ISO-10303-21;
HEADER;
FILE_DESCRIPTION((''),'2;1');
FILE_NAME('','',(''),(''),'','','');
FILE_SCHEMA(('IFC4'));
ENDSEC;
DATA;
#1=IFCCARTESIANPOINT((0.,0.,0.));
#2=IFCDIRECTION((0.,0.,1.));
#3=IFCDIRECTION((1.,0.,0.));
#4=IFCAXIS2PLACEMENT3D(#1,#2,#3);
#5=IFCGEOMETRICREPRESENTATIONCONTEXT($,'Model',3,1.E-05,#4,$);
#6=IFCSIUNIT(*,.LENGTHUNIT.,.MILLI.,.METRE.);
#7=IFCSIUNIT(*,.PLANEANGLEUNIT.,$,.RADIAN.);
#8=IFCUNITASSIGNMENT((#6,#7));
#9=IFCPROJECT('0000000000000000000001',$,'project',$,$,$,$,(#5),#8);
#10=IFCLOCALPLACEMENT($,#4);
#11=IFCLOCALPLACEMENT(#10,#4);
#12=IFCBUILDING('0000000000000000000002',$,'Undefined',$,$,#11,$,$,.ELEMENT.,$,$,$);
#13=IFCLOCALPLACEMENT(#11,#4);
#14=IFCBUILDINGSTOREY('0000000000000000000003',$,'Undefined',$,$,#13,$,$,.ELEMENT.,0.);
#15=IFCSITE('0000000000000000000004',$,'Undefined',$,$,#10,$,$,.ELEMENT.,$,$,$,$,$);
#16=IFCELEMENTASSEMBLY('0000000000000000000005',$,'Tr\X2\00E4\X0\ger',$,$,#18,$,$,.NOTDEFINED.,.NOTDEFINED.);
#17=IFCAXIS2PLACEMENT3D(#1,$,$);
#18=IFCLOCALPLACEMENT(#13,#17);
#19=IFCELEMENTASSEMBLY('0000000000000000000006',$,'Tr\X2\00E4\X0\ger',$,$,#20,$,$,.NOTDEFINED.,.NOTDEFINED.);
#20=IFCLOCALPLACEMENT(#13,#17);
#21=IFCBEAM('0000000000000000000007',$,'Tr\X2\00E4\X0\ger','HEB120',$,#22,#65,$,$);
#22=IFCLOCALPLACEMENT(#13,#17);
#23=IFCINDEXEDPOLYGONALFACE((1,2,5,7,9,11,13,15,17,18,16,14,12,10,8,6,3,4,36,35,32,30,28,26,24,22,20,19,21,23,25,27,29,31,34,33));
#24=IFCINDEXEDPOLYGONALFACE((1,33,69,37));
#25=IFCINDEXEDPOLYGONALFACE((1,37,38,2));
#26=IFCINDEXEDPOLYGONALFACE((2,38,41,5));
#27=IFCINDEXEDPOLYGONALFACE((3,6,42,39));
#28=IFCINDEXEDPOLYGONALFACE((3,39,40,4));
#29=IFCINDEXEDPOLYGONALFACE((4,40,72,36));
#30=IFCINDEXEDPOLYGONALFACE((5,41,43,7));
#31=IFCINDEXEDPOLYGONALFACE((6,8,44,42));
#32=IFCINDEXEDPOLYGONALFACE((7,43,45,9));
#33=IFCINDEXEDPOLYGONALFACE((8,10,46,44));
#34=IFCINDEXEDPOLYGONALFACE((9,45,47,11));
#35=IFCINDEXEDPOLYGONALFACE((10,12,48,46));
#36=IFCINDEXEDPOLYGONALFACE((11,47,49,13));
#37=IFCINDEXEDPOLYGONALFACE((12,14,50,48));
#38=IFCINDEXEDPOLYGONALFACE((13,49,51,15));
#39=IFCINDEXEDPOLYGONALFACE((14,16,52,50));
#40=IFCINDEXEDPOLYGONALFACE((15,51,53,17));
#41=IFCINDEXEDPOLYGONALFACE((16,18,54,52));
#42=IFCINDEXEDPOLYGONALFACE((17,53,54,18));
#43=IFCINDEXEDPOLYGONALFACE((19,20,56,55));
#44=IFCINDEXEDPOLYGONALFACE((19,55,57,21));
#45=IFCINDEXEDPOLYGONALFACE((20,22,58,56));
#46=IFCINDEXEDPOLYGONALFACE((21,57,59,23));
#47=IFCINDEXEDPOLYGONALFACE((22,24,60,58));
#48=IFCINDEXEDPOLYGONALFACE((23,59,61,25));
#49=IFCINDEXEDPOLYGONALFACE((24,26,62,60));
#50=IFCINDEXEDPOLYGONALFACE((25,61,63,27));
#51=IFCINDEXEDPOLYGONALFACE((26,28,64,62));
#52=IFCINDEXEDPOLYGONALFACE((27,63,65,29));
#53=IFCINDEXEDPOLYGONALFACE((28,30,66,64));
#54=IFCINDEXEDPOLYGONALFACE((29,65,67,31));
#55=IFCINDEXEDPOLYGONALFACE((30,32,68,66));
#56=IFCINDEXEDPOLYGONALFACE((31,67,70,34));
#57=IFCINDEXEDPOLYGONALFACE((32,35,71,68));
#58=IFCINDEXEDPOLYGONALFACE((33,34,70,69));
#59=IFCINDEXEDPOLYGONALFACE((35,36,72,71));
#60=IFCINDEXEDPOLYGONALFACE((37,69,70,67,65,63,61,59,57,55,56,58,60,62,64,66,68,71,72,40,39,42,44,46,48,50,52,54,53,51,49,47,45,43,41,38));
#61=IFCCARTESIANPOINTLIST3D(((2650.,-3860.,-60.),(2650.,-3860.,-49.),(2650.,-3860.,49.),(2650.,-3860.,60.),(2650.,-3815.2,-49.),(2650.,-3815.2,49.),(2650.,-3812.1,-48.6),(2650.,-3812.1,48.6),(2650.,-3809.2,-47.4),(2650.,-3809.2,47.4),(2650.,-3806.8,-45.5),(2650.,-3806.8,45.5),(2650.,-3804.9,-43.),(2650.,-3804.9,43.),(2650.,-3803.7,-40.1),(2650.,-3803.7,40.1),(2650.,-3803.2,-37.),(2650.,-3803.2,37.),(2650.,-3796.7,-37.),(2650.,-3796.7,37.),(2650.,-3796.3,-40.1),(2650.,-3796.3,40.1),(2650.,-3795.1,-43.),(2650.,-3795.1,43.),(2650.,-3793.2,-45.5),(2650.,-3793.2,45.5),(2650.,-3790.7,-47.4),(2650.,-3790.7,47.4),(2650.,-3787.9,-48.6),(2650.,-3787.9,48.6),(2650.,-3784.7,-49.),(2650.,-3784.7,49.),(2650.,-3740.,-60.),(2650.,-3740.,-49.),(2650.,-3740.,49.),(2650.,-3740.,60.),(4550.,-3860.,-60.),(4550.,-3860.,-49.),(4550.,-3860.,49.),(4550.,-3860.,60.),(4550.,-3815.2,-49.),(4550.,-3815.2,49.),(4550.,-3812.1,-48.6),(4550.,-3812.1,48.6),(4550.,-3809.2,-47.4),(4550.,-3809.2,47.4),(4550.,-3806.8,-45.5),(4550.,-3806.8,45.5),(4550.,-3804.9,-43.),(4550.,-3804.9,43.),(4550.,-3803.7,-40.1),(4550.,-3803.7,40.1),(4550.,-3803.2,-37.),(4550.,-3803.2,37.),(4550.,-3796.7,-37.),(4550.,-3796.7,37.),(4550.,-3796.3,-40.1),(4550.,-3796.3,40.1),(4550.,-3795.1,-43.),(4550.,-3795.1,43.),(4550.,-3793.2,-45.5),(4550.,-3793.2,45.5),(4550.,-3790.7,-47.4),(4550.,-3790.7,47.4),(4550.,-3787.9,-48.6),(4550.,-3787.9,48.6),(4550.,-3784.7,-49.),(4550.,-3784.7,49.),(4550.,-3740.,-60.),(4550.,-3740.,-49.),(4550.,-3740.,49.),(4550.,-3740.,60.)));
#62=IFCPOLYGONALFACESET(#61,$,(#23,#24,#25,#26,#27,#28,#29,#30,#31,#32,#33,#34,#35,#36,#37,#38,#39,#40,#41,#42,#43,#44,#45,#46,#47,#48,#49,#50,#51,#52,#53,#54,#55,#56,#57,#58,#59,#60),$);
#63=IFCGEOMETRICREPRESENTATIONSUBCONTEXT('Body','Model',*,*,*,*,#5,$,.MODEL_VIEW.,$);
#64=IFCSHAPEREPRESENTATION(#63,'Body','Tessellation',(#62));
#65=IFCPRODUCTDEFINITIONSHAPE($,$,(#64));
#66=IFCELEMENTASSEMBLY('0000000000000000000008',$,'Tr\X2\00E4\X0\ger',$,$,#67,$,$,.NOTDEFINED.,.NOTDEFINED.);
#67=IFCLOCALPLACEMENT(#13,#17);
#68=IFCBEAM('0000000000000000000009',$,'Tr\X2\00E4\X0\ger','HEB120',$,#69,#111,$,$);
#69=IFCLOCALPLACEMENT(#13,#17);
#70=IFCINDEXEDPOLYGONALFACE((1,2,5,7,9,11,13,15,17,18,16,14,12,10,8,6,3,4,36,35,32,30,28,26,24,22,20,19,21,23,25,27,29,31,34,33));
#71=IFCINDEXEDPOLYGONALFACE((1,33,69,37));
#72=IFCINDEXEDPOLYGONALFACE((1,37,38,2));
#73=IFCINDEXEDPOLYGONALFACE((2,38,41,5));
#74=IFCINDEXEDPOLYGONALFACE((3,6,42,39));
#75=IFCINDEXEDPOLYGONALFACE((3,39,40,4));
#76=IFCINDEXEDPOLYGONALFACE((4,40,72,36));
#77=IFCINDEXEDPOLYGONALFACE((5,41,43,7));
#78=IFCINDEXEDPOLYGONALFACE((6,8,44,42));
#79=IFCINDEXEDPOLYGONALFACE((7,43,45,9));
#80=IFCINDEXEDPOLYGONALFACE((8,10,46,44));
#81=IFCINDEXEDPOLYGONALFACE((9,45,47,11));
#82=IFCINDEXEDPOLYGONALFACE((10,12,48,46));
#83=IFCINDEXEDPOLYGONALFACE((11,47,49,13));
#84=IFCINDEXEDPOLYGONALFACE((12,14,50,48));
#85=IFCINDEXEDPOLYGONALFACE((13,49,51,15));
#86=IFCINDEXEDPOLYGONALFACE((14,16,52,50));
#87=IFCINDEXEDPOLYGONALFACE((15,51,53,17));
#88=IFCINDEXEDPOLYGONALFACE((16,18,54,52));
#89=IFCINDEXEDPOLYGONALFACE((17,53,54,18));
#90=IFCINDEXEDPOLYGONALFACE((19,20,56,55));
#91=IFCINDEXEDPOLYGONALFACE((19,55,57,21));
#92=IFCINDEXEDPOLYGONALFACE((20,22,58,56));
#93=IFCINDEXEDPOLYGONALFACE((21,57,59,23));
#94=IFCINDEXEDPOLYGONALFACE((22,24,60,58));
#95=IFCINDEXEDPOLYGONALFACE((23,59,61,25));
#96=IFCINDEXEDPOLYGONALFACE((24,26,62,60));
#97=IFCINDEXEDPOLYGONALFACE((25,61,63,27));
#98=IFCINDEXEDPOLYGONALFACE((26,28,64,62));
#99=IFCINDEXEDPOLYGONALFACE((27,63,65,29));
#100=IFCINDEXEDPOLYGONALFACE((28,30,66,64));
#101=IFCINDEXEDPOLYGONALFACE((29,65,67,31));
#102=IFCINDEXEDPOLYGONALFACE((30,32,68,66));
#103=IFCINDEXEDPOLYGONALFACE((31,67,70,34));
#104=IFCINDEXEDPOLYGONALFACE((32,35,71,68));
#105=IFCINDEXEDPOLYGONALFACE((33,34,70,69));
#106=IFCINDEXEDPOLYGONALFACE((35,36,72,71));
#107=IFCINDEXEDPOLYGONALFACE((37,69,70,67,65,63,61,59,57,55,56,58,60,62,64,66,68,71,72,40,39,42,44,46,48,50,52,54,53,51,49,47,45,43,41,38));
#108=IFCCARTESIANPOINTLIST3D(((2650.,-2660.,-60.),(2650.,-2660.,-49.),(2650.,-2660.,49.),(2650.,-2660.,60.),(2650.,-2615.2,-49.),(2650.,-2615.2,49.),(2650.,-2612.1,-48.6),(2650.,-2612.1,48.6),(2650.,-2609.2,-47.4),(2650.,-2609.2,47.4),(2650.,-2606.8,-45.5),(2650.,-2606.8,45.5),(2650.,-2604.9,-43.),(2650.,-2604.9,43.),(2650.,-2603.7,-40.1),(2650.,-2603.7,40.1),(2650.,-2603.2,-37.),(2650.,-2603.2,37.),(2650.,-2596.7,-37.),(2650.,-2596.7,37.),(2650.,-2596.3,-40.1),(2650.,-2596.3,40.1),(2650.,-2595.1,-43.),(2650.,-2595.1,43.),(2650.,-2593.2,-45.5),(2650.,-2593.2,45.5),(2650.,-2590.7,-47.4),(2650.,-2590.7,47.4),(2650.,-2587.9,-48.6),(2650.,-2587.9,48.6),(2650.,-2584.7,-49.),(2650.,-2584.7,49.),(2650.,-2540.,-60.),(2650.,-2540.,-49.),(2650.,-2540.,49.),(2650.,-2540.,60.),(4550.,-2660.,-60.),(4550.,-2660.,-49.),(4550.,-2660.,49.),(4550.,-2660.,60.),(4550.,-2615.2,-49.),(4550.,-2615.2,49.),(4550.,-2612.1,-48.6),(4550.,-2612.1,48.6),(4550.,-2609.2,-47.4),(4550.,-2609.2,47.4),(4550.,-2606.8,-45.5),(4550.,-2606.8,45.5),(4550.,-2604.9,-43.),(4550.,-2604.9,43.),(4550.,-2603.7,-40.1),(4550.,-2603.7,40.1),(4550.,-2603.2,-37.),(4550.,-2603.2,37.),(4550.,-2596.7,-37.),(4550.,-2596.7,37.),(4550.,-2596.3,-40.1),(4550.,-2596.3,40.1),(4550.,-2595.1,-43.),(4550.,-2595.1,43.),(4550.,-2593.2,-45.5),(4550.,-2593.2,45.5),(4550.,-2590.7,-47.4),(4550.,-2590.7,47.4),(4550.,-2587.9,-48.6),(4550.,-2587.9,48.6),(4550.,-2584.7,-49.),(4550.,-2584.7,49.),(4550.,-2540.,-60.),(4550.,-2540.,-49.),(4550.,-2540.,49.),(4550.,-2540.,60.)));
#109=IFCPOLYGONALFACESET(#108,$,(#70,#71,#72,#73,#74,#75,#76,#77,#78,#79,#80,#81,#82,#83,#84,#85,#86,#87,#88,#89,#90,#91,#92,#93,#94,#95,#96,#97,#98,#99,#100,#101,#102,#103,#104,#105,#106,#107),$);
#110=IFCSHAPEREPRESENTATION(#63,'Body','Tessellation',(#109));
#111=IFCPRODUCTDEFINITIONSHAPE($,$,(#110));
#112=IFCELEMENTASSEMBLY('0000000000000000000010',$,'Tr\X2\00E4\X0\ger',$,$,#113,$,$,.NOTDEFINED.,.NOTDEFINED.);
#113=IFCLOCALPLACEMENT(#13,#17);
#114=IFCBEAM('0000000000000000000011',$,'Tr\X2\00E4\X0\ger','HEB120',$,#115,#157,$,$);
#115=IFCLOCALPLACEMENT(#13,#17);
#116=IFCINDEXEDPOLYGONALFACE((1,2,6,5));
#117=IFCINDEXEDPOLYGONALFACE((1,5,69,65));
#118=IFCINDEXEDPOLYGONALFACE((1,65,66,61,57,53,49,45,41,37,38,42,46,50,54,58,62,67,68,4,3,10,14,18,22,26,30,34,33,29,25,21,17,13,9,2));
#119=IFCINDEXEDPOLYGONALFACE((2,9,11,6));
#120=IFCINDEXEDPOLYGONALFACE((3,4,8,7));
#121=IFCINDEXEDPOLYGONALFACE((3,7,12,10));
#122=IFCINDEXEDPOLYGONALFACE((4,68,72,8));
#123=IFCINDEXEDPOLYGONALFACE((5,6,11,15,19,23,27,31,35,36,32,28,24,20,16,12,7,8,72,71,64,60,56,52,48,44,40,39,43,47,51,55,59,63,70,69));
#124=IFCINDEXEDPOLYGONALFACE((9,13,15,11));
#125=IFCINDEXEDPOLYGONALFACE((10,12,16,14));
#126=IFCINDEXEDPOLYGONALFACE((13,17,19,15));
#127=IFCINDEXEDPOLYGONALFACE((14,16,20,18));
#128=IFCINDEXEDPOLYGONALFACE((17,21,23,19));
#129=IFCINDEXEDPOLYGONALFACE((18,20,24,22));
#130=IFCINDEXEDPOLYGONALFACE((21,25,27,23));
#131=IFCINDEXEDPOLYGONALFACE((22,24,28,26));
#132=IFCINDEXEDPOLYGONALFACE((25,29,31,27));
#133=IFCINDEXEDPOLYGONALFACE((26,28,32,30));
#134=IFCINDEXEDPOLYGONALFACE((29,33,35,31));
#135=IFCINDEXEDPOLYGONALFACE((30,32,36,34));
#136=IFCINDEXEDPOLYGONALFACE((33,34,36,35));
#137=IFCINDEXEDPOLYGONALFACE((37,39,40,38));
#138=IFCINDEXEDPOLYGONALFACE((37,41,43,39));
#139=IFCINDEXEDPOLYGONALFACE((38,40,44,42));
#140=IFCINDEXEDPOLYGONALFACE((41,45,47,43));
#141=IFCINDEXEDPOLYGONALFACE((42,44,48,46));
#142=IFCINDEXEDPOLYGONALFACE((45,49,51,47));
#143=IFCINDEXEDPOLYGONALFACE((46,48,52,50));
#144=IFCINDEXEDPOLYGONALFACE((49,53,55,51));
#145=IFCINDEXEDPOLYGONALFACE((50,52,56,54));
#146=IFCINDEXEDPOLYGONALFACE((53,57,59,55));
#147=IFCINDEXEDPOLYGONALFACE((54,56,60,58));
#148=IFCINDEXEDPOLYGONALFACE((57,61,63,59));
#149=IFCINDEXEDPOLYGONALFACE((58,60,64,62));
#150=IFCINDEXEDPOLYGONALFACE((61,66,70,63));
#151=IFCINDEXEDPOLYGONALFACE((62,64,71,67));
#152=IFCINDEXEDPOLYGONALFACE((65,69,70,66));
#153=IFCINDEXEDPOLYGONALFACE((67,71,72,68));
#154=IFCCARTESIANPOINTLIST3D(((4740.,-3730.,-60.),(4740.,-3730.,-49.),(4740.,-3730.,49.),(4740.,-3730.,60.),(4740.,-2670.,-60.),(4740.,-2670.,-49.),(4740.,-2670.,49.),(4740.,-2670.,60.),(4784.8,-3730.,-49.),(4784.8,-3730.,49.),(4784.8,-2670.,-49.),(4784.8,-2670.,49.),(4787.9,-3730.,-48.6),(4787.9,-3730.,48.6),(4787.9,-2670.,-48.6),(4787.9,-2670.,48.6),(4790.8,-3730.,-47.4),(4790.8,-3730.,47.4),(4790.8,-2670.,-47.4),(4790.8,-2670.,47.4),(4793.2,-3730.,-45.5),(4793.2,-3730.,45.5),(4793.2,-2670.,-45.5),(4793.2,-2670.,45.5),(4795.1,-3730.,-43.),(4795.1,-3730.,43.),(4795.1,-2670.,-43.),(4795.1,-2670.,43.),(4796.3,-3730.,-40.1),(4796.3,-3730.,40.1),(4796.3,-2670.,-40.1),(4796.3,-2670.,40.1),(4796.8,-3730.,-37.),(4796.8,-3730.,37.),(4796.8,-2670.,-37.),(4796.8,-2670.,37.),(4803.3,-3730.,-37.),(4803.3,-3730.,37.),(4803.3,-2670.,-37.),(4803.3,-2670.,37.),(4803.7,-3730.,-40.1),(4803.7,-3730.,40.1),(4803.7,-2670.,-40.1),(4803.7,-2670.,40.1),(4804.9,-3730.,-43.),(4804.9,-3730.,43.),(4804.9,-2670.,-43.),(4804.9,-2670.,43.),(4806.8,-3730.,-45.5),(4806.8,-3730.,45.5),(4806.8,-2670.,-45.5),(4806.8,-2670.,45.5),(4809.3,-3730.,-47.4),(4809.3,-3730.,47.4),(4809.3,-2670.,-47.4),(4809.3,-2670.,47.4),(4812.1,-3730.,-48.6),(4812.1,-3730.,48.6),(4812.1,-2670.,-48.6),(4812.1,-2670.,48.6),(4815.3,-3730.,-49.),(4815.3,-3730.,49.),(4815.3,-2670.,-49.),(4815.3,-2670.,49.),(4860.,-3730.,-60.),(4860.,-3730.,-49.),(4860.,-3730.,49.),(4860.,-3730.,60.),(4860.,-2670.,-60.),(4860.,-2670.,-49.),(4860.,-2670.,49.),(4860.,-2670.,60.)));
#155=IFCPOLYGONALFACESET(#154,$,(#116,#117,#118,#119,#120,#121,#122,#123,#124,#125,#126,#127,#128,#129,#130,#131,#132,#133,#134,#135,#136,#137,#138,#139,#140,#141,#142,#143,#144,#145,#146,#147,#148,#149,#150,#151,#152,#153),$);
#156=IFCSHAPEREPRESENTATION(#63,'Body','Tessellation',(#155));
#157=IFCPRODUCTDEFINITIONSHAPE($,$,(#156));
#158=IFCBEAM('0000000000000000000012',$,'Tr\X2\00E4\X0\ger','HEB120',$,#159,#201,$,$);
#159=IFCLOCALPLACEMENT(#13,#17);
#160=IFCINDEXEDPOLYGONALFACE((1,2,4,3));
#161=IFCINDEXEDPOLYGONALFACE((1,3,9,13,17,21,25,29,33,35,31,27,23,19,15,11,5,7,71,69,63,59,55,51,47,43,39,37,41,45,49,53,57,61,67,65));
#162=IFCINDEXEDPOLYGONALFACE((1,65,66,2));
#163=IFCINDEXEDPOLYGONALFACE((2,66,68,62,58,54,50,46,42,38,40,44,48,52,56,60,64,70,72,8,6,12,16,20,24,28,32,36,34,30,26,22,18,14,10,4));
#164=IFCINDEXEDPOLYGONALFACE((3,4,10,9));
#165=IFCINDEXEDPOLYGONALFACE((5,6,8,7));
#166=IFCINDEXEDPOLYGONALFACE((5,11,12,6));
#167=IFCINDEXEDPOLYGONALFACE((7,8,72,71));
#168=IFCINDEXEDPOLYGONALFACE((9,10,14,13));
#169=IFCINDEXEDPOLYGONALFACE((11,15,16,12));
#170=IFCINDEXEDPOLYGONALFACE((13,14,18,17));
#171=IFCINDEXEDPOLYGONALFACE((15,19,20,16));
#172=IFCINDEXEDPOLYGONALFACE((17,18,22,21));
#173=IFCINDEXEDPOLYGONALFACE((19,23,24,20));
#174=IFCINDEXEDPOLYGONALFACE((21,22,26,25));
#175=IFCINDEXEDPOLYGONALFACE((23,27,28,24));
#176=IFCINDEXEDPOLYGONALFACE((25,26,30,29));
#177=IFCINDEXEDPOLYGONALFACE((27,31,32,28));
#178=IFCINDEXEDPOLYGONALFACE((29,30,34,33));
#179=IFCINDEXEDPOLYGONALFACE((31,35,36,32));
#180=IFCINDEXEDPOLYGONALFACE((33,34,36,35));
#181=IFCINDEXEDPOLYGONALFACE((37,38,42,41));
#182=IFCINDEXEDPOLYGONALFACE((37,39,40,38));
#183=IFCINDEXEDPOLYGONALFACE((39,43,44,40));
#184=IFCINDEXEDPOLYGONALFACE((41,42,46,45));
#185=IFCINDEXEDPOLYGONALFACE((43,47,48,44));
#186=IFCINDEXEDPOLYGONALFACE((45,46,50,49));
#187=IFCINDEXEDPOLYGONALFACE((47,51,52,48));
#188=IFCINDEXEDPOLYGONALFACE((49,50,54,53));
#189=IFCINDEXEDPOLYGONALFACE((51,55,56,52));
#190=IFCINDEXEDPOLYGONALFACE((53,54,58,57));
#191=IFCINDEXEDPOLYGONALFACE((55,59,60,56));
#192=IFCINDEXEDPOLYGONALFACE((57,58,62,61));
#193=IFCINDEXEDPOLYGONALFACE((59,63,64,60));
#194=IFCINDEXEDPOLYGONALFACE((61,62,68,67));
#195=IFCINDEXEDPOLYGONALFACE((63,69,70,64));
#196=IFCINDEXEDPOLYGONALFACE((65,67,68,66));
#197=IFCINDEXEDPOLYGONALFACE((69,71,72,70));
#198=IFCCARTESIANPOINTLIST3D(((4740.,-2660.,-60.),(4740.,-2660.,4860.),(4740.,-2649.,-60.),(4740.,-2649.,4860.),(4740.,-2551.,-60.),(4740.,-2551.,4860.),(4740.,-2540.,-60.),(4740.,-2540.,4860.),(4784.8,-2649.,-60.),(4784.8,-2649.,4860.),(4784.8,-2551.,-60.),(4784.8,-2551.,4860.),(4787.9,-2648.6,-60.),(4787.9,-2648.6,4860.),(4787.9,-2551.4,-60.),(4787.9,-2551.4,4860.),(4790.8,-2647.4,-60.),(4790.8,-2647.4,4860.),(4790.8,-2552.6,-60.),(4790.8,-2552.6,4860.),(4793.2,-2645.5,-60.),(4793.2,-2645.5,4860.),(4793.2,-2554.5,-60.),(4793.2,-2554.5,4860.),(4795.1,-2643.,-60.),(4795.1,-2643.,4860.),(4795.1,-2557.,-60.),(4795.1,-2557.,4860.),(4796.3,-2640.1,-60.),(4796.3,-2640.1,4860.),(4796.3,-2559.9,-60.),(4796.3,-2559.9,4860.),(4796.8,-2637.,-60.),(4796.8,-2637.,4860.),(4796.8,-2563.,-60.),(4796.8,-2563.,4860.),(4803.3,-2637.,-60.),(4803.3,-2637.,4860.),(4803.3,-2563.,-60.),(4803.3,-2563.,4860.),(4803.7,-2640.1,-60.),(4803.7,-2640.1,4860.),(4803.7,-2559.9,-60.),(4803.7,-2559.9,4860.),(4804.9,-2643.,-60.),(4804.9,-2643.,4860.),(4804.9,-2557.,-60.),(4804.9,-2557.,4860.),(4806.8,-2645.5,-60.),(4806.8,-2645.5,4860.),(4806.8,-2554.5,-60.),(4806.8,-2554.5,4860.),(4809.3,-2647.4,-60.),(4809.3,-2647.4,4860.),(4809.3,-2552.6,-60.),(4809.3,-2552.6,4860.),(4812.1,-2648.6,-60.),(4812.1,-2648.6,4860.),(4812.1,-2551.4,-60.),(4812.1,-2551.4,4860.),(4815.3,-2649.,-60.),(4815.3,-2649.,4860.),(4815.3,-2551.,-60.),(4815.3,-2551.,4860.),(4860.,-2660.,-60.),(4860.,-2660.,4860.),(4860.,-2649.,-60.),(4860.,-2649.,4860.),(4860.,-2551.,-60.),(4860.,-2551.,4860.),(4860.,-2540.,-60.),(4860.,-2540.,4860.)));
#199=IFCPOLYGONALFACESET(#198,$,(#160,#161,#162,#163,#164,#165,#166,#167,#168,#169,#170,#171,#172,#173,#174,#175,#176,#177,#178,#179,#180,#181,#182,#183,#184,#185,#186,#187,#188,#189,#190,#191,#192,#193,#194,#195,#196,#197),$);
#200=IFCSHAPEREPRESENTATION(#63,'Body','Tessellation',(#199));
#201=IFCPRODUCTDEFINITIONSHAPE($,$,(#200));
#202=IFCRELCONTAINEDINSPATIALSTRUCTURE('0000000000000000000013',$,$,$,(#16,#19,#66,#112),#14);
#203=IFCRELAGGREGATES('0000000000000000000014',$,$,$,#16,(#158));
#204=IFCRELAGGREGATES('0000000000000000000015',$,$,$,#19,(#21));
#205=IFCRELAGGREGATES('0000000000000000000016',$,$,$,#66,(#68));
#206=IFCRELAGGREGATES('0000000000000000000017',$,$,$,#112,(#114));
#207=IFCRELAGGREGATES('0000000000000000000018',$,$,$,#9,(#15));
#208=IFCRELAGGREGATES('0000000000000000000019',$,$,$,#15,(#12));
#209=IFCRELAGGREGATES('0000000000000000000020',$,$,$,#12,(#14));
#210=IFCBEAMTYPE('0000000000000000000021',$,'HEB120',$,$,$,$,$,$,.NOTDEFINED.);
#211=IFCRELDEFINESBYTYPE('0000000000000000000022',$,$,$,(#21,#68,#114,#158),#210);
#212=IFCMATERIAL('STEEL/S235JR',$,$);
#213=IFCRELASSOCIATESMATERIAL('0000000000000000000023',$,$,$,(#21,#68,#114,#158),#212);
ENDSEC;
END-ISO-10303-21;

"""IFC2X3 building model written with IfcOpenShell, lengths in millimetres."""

from ifc_helpers import new_model, si_unit, frame, origin_with_axes, origin_2d_with_axis, place, context, subcontext, project, spatial, i_section, extrude, clip, halfspace, material, type_object, element, aggregate, save


model = new_model("IFC2X3")

# Units and contexts
model_context = context("Model", 3, precision=1e-05, world=origin_with_axes())
body_context = subcontext(model_context, "Body", "Model", "MODEL_VIEW")
ifc_project = project(units=[si_unit("LENGTHUNIT", "METRE", prefix="MILLI"), si_unit("PLANEANGLEUNIT", "RADIAN")], contexts=[model_context])

# Site, building, storey
site_placement = place(None, origin_with_axes())
site = spatial("IfcSite", under=ifc_project, at=site_placement, Name="Undefined", CompositionType="ELEMENT")
building_placement = place(site_placement, origin_with_axes())
building = spatial("IfcBuilding", under=site, at=building_placement, Name="Undefined", CompositionType="ELEMENT")
storey_placement = place(building_placement, origin_with_axes())
storey = spatial("IfcBuildingStorey", under=building, at=storey_placement, Name="Undefined", CompositionType="ELEMENT", Elevation=0.0)

# Shared definitions
ifc_material_1 = material(Name="STEEL/S235JR")

# Element assemblies, beams
beam_type = type_object("IfcBeamType", Name="HEB120", PredefinedType="NOTDEFINED")
assembly_1_placement = place(storey_placement, origin_with_axes())
assembly_1 = element("IfcElementAssembly", 1, at=assembly_1_placement, inside=storey, Name="Träger", AssemblyPlace="NOTDEFINED", PredefinedType="NOTDEFINED")
assembly_2_placement = place(storey_placement, origin_with_axes())
assembly_2 = element("IfcElementAssembly", 2, at=assembly_2_placement, inside=storey, Name="Träger", AssemblyPlace="NOTDEFINED", PredefinedType="NOTDEFINED")
beam_1_placement = place(assembly_2_placement, frame((4550.0, -3800.0, 0.0), z_axis=(0.0, 0.0, 1.0), x_axis=(-1.0, 0.0, 0.0)))
beam_1 = element("IfcBeam", 3, at=beam_1_placement, type_object=beam_type, material=ifc_material_1, Name="Träger", Description="HEB120", context=body_context, shape_type="Clipping", body=[
    clip(clip(extrude(i_section(OverallWidth=120.0, OverallDepth=120.0, WebThickness=6.5, FlangeThickness=11.0, FilletRadius=12.0, at=origin_2d_with_axis()), frame((1910.0, 0.0, 0.0), z_axis=(-1.0, 0.0, 0.0), x_axis=(0.0, -1.0, 0.0)), (0.0, 0.0, 1.0), 1910.0), halfspace(frame((1900.0, 0.0, -60.0), z_axis=(-1.0, 0.0, 0.0), x_axis=(0.0, 1.0, 0.0)), True)), halfspace(frame((0.0, 0.0, -60.0), z_axis=(1.0, 0.0, 0.0), x_axis=(0.0, -1.0, 0.0)), True)),
])
assembly_3_placement = place(storey_placement, origin_with_axes())
assembly_3 = element("IfcElementAssembly", 4, at=assembly_3_placement, inside=storey, Name="Träger", AssemblyPlace="NOTDEFINED", PredefinedType="NOTDEFINED")
beam_2_placement = place(assembly_3_placement, frame((4550.0, -2600.0, 0.0), z_axis=(0.0, 0.0, 1.0), x_axis=(-1.0, 0.0, 0.0)))
beam_2 = element("IfcBeam", 5, at=beam_2_placement, type_object=beam_type, material=ifc_material_1, Name="Träger", Description="HEB120", context=body_context, shape_type="Clipping", body=[
    clip(clip(extrude(i_section(OverallWidth=120.0, OverallDepth=120.0, WebThickness=6.5, FlangeThickness=11.0, FilletRadius=12.0, at=origin_2d_with_axis()), frame((1910.0, 0.0, 0.0), z_axis=(-1.0, 0.0, 0.0), x_axis=(0.0, -1.0, 0.0)), (0.0, 0.0, 1.0), 1910.0), halfspace(frame((1900.0, 0.0, -60.0), z_axis=(-1.0, 0.0, 0.0), x_axis=(0.0, 1.0, 0.0)), True)), halfspace(frame((0.0, 0.0, -60.0), z_axis=(1.0, 0.0, 0.0), x_axis=(0.0, -1.0, 0.0)), True)),
])
assembly_4_placement = place(storey_placement, origin_with_axes())
assembly_4 = element("IfcElementAssembly", 6, at=assembly_4_placement, inside=storey, Name="Träger", AssemblyPlace="NOTDEFINED", PredefinedType="NOTDEFINED")
beam_3_placement = place(assembly_4_placement, frame((4800.0, -2670.0, 0.0), z_axis=(0.0, 0.0, 1.0), x_axis=(0.0, -1.0, 0.0)))
beam_3 = element("IfcBeam", 7, at=beam_3_placement, type_object=beam_type, material=ifc_material_1, Name="Träger", Description="HEB120", context=body_context, shape_type="Clipping", body=[
    clip(clip(extrude(i_section(OverallWidth=120.0, OverallDepth=120.0, WebThickness=6.5, FlangeThickness=11.0, FilletRadius=12.0, at=origin_2d_with_axis()), frame((1060.0, 0.0, 0.0), z_axis=(-1.0, 0.0, 0.0), x_axis=(0.0, -1.0, 0.0)), (0.0, 0.0, 1.0), 1060.0), halfspace(frame((1060.0, 0.0, -60.0), z_axis=(-1.0, 0.0, 0.0), x_axis=(0.0, 1.0, 0.0)), True)), halfspace(frame((0.0, 0.0, -60.0), z_axis=(1.0, 0.0, 0.0), x_axis=(0.0, -1.0, 0.0)), True)),
])

# Beam
beam_4_placement = place(assembly_1_placement, frame((4800.0, -2600.0, -60.0), z_axis=(0.0, 1.0, 0.0), x_axis=(0.0, 0.0, 1.0)))
beam_4 = element("IfcBeam", 8, at=beam_4_placement, type_object=beam_type, material=ifc_material_1, Name="Träger", Description="HEB120", context=body_context, shape_type="SweptSolid", body=[
    extrude(i_section(OverallWidth=120.0, OverallDepth=120.0, WebThickness=6.5, FlangeThickness=11.0, FilletRadius=12.0, at=origin_2d_with_axis()), frame((4920.0, 0.0, 0.0), z_axis=(-1.0, 0.0, 0.0), x_axis=(0.0, -1.0, 0.0)), (0.0, 0.0, 1.0), 4920.0),
])

aggregate(assembly_1, [beam_4])

aggregate(assembly_2, [beam_1])
aggregate(assembly_3, [beam_2])
aggregate(assembly_4, [beam_3])

save(model, "model.ifc")
